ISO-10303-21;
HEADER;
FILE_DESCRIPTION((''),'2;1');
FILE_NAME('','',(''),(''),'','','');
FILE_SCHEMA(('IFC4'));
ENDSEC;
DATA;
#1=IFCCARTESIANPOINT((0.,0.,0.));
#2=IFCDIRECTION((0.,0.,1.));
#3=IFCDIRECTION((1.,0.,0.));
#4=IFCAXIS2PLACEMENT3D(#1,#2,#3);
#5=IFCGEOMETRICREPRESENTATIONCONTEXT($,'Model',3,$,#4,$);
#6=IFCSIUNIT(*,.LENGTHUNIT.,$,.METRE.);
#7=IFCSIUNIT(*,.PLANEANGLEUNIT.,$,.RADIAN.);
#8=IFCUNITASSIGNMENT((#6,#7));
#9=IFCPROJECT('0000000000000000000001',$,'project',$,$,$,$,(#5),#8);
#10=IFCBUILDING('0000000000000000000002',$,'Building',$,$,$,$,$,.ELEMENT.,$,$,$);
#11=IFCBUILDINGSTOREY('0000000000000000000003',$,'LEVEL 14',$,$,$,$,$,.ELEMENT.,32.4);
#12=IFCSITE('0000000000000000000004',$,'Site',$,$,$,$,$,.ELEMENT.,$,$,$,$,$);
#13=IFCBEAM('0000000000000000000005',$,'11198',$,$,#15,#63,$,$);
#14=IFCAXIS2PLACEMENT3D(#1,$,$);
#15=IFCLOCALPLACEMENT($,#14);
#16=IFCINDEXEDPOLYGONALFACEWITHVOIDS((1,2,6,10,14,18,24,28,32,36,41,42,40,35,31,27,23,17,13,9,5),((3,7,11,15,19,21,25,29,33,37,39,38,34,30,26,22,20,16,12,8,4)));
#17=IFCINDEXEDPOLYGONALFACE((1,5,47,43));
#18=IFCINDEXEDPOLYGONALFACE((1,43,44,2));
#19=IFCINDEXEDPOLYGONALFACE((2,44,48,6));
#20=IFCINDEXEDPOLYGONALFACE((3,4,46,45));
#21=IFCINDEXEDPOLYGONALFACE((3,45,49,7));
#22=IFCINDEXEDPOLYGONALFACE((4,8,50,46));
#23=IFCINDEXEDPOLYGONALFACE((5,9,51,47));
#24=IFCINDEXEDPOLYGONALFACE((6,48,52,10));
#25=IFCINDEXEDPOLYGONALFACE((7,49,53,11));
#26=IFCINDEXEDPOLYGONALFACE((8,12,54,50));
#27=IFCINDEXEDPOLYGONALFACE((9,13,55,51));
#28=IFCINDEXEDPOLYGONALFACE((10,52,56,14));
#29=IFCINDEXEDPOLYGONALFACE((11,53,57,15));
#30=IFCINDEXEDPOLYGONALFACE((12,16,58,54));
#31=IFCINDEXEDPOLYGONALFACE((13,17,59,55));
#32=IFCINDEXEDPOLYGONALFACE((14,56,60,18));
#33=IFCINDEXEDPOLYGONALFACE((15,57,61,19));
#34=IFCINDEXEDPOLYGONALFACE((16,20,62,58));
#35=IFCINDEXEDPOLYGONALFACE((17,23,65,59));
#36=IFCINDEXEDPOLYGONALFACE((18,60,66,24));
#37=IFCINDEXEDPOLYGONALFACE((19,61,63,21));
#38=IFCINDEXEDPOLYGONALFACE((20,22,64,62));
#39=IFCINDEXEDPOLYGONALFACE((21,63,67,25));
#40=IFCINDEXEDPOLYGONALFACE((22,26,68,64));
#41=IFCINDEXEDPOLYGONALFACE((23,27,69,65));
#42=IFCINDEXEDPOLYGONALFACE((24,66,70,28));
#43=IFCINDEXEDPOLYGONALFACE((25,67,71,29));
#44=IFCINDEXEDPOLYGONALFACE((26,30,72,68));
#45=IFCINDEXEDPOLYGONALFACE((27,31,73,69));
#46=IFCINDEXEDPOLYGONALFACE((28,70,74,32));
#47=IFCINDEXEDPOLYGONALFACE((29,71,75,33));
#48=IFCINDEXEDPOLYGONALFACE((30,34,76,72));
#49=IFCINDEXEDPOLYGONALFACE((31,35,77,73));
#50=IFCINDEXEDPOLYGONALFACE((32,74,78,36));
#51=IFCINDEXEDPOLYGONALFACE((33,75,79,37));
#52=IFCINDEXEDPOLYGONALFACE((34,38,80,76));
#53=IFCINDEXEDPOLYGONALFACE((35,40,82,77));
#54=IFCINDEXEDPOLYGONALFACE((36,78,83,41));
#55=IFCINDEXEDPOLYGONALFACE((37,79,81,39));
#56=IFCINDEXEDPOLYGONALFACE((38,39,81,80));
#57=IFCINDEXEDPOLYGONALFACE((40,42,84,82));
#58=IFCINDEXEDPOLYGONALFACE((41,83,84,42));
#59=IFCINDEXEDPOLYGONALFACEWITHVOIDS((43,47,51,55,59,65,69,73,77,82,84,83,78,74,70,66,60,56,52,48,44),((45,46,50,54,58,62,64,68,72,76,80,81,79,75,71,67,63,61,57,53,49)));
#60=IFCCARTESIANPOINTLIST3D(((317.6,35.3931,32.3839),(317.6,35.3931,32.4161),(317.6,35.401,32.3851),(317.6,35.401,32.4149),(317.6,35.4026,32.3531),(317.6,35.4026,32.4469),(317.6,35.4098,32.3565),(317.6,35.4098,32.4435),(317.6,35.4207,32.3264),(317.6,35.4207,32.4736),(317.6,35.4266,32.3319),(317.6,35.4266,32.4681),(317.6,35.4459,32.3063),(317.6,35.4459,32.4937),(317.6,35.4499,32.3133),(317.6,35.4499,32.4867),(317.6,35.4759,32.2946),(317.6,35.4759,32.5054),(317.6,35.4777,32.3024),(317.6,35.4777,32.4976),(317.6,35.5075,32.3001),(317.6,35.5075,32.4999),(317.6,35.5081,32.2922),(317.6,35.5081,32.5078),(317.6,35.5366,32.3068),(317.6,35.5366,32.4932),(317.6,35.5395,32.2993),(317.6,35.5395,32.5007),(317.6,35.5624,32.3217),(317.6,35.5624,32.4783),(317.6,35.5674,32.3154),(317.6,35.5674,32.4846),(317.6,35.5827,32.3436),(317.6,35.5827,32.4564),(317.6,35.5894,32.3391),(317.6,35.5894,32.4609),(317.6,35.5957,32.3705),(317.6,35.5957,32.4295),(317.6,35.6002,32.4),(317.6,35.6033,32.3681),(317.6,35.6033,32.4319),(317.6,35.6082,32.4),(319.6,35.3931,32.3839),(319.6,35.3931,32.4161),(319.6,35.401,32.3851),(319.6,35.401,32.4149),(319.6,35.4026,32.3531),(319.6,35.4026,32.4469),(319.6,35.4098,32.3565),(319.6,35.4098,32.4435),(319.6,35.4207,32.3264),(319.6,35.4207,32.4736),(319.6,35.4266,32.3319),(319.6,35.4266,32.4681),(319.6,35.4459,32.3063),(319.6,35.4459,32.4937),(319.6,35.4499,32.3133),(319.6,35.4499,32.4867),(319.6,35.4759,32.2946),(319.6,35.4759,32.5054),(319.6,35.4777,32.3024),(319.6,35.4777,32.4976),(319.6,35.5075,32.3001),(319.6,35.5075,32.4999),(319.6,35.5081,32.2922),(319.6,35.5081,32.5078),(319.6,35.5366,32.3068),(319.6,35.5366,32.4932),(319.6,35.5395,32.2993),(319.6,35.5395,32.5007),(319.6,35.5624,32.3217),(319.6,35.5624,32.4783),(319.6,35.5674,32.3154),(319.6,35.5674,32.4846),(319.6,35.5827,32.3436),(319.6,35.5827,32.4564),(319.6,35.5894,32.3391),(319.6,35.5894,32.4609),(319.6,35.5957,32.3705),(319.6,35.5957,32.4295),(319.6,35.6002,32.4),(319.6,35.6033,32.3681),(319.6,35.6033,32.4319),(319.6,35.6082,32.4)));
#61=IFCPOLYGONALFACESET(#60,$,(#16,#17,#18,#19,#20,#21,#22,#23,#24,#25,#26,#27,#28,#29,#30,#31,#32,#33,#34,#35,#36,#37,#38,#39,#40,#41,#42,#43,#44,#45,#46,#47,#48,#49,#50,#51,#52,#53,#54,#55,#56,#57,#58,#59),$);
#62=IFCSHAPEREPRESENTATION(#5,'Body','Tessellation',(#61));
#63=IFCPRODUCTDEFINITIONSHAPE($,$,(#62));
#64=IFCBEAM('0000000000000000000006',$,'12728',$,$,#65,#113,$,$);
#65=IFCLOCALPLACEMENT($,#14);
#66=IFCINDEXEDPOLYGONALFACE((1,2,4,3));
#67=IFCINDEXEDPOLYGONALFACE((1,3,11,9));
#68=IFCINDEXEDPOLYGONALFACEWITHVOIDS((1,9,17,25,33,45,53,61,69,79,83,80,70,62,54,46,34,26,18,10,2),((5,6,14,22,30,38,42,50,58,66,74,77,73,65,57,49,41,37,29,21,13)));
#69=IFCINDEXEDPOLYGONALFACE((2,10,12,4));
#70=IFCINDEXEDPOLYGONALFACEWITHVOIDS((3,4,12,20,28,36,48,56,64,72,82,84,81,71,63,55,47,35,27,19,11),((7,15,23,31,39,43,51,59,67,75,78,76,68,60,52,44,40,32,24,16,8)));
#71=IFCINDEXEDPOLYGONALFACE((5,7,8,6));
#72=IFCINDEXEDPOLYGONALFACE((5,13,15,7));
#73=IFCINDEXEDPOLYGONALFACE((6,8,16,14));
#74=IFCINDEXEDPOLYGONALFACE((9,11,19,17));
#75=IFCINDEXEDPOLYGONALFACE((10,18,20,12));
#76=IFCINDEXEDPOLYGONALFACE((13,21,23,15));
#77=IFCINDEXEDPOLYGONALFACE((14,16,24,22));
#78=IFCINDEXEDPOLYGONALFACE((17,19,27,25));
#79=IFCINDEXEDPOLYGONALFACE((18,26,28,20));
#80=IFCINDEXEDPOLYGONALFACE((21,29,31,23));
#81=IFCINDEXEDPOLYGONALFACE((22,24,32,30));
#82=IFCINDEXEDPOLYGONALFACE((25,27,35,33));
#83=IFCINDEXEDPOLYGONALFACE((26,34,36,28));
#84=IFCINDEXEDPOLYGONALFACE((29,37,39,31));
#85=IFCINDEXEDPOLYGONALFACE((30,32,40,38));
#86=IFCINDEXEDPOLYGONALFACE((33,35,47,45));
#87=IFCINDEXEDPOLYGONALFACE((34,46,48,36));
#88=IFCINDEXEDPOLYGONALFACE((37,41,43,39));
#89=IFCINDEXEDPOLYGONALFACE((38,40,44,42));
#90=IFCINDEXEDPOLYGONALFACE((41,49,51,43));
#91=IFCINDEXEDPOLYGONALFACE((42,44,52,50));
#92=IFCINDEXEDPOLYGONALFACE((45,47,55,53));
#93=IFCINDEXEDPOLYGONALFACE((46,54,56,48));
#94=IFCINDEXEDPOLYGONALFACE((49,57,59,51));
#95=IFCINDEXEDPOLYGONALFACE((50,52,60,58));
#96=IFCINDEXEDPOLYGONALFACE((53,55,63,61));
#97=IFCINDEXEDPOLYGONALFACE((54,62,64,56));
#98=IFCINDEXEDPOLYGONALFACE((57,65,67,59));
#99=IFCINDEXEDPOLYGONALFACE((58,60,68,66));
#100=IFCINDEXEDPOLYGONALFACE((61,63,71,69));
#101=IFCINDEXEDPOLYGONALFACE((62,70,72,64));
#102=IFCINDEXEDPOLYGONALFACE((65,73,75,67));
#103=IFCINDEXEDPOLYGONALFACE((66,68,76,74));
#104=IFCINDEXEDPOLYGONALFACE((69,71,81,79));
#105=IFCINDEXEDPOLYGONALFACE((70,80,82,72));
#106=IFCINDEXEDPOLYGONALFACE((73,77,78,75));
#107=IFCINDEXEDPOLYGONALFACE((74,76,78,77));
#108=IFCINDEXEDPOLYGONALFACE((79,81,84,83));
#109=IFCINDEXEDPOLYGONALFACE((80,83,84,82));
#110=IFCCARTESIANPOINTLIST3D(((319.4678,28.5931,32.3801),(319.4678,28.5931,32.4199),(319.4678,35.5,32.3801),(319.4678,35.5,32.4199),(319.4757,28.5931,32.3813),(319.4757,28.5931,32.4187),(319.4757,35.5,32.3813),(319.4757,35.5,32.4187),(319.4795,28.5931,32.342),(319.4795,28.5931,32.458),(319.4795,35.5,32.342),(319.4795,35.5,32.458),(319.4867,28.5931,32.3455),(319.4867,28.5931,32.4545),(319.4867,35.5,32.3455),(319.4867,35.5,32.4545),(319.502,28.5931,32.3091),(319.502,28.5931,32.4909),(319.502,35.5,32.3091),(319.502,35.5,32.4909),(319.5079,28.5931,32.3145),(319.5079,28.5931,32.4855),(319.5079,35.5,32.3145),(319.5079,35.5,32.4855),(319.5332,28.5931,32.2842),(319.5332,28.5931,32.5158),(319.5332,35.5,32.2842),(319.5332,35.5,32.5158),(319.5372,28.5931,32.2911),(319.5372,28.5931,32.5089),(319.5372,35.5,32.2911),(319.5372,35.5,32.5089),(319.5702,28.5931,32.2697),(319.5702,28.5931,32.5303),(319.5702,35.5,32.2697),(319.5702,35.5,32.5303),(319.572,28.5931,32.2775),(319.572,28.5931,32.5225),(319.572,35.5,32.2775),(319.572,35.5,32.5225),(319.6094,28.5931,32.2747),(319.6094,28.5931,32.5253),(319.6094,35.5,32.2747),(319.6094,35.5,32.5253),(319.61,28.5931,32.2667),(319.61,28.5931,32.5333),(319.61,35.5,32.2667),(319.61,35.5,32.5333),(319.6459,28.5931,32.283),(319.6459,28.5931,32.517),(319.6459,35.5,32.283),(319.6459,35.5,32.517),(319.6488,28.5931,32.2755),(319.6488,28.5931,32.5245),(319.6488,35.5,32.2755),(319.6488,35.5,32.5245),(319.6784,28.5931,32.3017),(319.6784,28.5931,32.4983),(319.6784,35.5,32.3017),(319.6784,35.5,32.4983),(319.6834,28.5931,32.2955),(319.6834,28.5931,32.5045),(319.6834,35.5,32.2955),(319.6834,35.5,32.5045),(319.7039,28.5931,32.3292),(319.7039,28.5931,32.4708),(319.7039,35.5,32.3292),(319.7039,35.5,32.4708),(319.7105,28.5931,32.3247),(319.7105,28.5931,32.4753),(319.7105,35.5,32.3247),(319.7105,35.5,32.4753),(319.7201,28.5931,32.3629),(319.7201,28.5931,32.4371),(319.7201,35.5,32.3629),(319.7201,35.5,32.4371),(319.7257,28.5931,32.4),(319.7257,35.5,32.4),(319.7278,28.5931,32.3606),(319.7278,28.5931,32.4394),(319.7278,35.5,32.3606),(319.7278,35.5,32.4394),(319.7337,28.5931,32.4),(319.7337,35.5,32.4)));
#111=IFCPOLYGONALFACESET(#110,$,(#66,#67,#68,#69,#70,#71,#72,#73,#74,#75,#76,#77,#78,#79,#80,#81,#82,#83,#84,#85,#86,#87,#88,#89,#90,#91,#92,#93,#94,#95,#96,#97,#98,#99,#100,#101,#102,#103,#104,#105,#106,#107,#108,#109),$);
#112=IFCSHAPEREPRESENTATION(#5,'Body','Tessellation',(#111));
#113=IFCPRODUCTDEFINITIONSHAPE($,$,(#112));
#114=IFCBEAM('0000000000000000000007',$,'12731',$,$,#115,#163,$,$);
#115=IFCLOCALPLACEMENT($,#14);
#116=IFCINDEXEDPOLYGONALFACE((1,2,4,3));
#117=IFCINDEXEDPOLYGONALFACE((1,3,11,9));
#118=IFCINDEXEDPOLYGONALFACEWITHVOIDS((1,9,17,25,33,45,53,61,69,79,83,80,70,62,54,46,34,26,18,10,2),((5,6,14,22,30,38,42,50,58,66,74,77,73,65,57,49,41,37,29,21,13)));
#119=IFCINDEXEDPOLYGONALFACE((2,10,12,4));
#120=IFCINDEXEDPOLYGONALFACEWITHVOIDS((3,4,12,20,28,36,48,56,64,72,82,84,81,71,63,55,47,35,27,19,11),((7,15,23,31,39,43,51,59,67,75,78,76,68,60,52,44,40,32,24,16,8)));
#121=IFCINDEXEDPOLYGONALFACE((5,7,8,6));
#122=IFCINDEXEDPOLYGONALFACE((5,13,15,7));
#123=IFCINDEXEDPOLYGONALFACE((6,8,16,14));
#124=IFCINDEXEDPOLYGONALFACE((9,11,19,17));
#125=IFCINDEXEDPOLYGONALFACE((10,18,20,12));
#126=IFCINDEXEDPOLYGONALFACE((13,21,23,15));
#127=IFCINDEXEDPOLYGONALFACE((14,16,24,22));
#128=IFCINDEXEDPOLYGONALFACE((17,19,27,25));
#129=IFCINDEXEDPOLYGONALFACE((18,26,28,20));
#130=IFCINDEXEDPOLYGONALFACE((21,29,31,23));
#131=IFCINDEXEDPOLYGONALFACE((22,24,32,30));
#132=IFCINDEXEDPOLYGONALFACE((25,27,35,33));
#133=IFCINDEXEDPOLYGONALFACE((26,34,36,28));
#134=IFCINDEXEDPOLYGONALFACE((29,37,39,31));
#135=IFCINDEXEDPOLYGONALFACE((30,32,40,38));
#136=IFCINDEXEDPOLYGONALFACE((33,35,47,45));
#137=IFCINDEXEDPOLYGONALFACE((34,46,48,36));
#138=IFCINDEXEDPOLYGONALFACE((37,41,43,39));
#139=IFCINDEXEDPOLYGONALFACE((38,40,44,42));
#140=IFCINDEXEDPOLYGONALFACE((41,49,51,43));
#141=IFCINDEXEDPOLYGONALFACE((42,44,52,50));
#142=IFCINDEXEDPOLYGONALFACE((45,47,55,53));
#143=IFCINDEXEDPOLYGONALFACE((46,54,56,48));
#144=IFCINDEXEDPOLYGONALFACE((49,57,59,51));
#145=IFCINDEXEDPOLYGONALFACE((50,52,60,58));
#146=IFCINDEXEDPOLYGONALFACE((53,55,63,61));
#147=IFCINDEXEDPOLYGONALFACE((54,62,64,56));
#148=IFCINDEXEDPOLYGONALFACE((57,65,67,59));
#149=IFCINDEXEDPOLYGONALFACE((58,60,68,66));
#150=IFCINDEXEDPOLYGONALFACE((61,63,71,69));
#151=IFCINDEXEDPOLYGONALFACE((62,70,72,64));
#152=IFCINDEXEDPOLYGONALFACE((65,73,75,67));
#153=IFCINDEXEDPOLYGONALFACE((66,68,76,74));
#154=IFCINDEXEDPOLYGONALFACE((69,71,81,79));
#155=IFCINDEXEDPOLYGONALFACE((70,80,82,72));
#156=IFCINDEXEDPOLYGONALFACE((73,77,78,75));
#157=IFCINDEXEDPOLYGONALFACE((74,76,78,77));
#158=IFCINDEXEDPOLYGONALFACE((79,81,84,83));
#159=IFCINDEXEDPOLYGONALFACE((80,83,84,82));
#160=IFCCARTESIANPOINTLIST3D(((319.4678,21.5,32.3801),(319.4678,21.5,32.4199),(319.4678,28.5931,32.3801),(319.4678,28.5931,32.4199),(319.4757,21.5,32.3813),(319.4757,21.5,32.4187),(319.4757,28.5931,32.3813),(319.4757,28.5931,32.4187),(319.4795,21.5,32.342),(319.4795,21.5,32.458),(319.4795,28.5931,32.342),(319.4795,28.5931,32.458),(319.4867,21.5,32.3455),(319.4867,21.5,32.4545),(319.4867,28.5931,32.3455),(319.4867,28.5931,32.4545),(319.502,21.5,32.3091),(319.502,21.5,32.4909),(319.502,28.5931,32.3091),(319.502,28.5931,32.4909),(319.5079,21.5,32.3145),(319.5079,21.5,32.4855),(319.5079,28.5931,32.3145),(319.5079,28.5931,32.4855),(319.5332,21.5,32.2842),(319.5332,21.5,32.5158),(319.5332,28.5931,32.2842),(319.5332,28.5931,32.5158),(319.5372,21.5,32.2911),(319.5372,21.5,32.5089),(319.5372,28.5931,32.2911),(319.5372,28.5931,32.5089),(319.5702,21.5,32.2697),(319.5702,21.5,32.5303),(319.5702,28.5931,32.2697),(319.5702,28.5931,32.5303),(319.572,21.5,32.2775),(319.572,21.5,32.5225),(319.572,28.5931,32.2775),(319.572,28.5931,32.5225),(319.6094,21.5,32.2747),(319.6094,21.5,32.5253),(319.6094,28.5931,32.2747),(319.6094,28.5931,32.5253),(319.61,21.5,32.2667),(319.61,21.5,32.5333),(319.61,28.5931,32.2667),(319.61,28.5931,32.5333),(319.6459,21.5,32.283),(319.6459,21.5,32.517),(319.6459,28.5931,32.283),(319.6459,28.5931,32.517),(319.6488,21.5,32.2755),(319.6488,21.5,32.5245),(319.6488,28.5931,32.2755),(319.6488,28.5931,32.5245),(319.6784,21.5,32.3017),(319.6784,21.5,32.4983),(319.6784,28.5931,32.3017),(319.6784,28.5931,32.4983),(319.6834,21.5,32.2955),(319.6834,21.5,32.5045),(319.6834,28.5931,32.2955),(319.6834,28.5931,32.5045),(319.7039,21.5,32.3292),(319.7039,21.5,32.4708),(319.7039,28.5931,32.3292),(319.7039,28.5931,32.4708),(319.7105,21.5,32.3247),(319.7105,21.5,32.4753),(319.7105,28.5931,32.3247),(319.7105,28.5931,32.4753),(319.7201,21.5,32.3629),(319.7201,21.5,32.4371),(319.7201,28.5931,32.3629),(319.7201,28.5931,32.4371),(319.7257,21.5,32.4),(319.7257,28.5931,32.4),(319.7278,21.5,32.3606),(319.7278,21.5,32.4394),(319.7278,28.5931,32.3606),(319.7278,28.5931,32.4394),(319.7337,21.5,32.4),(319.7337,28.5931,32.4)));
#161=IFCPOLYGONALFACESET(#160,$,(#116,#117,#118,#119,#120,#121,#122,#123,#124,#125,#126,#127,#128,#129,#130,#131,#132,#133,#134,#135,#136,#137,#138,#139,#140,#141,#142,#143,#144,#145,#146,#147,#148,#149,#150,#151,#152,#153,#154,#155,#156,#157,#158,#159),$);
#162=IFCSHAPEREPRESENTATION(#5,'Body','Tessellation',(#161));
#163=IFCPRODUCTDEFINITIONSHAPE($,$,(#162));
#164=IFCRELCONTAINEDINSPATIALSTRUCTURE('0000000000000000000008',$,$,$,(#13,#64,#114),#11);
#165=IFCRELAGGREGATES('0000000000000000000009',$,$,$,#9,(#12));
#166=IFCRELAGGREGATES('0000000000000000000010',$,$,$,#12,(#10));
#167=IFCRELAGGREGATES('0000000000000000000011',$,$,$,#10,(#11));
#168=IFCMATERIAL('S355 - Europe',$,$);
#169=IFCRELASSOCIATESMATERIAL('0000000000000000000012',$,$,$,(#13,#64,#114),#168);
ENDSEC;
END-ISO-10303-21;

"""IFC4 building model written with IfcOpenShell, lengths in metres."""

from ifc_helpers import new_model, si_unit, frame, origin_with_axes, origin_2d_with_axis, place, context, project, spatial, hollow_circle, extrude, material, material_profile, profile_set, profile_usage, element, save


model = new_model("IFC4")

# Units and contexts
model_context = context("Model", 3, world=origin_with_axes())
ifc_project = project(units=[si_unit("LENGTHUNIT", "METRE"), si_unit("PLANEANGLEUNIT", "RADIAN")], contexts=[model_context])

# Site, building, storey
site = spatial("IfcSite", under=ifc_project, Name="Site", CompositionType="ELEMENT")
building = spatial("IfcBuilding", under=site, Name="Building", CompositionType="ELEMENT")
storey = spatial("IfcBuildingStorey", under=building, Name="LEVEL 14", CompositionType="ELEMENT", Elevation=32.4)

# Shared definitions
ifc_material = material(Name="S355 - Europe")

# Beams
ifc_material_profile_1 = material_profile(ifc_material, hollow_circle(Radius=0.1081, WallThickness=0.008, at=origin_2d_with_axis()))
ifc_profile_set_1 = profile_set([ifc_material_profile_1])
ifc_profile_usage_1 = profile_usage(ifc_profile_set_1, cardinal=10)
beam_1_placement = place(None, frame((317.6, 35.5, 32.4), z_axis=(1.0, 0.0, 0.0), x_axis=(0.0, 1.0, 0.0)))
element("IfcBeam", 1, at=beam_1_placement, inside=storey, material=ifc_profile_usage_1, Name="11198", context=model_context, shape_type="SweptSolid", body=[
    extrude(hollow_circle(Radius=0.1081, WallThickness=0.008, at=origin_2d_with_axis()), origin_with_axes(), (0.0, 0.0, 1.0), 2.0),
])
ifc_material_profile_2 = material_profile(ifc_material, hollow_circle(Radius=0.1337, WallThickness=0.008, at=origin_2d_with_axis()))
ifc_profile_set_2 = profile_set([ifc_material_profile_2])
ifc_profile_usage_2 = profile_usage(ifc_profile_set_2, cardinal=10)
beam_2_placement = place(None, frame((319.6, 35.5, 32.4), z_axis=(0.0, -1.0, 0.0), x_axis=(1.0, 0.0, 0.0)))
element("IfcBeam", 2, at=beam_2_placement, inside=storey, material=ifc_profile_usage_2, Name="12728", context=model_context, shape_type="SweptSolid", body=[
    extrude(hollow_circle(Radius=0.1337, WallThickness=0.008, at=origin_2d_with_axis()), origin_with_axes(), (0.0, 0.0, 1.0), 6.9069),
])
ifc_material_profile_3 = material_profile(ifc_material, hollow_circle(Radius=0.1337, WallThickness=0.008, at=origin_2d_with_axis()))
ifc_profile_set_3 = profile_set([ifc_material_profile_3])
ifc_profile_usage_3 = profile_usage(ifc_profile_set_3, cardinal=10)
beam_3_placement = place(None, frame((319.6, 28.5931, 32.4), z_axis=(0.0, -1.0, 0.0), x_axis=(1.0, 0.0, 0.0)))
element("IfcBeam", 3, at=beam_3_placement, inside=storey, material=ifc_profile_usage_3, Name="12731", context=model_context, shape_type="SweptSolid", body=[
    extrude(hollow_circle(Radius=0.1337, WallThickness=0.008, at=origin_2d_with_axis()), origin_with_axes(), (0.0, 0.0, 1.0), 7.0931),
])

save(model, "model.ifc")
